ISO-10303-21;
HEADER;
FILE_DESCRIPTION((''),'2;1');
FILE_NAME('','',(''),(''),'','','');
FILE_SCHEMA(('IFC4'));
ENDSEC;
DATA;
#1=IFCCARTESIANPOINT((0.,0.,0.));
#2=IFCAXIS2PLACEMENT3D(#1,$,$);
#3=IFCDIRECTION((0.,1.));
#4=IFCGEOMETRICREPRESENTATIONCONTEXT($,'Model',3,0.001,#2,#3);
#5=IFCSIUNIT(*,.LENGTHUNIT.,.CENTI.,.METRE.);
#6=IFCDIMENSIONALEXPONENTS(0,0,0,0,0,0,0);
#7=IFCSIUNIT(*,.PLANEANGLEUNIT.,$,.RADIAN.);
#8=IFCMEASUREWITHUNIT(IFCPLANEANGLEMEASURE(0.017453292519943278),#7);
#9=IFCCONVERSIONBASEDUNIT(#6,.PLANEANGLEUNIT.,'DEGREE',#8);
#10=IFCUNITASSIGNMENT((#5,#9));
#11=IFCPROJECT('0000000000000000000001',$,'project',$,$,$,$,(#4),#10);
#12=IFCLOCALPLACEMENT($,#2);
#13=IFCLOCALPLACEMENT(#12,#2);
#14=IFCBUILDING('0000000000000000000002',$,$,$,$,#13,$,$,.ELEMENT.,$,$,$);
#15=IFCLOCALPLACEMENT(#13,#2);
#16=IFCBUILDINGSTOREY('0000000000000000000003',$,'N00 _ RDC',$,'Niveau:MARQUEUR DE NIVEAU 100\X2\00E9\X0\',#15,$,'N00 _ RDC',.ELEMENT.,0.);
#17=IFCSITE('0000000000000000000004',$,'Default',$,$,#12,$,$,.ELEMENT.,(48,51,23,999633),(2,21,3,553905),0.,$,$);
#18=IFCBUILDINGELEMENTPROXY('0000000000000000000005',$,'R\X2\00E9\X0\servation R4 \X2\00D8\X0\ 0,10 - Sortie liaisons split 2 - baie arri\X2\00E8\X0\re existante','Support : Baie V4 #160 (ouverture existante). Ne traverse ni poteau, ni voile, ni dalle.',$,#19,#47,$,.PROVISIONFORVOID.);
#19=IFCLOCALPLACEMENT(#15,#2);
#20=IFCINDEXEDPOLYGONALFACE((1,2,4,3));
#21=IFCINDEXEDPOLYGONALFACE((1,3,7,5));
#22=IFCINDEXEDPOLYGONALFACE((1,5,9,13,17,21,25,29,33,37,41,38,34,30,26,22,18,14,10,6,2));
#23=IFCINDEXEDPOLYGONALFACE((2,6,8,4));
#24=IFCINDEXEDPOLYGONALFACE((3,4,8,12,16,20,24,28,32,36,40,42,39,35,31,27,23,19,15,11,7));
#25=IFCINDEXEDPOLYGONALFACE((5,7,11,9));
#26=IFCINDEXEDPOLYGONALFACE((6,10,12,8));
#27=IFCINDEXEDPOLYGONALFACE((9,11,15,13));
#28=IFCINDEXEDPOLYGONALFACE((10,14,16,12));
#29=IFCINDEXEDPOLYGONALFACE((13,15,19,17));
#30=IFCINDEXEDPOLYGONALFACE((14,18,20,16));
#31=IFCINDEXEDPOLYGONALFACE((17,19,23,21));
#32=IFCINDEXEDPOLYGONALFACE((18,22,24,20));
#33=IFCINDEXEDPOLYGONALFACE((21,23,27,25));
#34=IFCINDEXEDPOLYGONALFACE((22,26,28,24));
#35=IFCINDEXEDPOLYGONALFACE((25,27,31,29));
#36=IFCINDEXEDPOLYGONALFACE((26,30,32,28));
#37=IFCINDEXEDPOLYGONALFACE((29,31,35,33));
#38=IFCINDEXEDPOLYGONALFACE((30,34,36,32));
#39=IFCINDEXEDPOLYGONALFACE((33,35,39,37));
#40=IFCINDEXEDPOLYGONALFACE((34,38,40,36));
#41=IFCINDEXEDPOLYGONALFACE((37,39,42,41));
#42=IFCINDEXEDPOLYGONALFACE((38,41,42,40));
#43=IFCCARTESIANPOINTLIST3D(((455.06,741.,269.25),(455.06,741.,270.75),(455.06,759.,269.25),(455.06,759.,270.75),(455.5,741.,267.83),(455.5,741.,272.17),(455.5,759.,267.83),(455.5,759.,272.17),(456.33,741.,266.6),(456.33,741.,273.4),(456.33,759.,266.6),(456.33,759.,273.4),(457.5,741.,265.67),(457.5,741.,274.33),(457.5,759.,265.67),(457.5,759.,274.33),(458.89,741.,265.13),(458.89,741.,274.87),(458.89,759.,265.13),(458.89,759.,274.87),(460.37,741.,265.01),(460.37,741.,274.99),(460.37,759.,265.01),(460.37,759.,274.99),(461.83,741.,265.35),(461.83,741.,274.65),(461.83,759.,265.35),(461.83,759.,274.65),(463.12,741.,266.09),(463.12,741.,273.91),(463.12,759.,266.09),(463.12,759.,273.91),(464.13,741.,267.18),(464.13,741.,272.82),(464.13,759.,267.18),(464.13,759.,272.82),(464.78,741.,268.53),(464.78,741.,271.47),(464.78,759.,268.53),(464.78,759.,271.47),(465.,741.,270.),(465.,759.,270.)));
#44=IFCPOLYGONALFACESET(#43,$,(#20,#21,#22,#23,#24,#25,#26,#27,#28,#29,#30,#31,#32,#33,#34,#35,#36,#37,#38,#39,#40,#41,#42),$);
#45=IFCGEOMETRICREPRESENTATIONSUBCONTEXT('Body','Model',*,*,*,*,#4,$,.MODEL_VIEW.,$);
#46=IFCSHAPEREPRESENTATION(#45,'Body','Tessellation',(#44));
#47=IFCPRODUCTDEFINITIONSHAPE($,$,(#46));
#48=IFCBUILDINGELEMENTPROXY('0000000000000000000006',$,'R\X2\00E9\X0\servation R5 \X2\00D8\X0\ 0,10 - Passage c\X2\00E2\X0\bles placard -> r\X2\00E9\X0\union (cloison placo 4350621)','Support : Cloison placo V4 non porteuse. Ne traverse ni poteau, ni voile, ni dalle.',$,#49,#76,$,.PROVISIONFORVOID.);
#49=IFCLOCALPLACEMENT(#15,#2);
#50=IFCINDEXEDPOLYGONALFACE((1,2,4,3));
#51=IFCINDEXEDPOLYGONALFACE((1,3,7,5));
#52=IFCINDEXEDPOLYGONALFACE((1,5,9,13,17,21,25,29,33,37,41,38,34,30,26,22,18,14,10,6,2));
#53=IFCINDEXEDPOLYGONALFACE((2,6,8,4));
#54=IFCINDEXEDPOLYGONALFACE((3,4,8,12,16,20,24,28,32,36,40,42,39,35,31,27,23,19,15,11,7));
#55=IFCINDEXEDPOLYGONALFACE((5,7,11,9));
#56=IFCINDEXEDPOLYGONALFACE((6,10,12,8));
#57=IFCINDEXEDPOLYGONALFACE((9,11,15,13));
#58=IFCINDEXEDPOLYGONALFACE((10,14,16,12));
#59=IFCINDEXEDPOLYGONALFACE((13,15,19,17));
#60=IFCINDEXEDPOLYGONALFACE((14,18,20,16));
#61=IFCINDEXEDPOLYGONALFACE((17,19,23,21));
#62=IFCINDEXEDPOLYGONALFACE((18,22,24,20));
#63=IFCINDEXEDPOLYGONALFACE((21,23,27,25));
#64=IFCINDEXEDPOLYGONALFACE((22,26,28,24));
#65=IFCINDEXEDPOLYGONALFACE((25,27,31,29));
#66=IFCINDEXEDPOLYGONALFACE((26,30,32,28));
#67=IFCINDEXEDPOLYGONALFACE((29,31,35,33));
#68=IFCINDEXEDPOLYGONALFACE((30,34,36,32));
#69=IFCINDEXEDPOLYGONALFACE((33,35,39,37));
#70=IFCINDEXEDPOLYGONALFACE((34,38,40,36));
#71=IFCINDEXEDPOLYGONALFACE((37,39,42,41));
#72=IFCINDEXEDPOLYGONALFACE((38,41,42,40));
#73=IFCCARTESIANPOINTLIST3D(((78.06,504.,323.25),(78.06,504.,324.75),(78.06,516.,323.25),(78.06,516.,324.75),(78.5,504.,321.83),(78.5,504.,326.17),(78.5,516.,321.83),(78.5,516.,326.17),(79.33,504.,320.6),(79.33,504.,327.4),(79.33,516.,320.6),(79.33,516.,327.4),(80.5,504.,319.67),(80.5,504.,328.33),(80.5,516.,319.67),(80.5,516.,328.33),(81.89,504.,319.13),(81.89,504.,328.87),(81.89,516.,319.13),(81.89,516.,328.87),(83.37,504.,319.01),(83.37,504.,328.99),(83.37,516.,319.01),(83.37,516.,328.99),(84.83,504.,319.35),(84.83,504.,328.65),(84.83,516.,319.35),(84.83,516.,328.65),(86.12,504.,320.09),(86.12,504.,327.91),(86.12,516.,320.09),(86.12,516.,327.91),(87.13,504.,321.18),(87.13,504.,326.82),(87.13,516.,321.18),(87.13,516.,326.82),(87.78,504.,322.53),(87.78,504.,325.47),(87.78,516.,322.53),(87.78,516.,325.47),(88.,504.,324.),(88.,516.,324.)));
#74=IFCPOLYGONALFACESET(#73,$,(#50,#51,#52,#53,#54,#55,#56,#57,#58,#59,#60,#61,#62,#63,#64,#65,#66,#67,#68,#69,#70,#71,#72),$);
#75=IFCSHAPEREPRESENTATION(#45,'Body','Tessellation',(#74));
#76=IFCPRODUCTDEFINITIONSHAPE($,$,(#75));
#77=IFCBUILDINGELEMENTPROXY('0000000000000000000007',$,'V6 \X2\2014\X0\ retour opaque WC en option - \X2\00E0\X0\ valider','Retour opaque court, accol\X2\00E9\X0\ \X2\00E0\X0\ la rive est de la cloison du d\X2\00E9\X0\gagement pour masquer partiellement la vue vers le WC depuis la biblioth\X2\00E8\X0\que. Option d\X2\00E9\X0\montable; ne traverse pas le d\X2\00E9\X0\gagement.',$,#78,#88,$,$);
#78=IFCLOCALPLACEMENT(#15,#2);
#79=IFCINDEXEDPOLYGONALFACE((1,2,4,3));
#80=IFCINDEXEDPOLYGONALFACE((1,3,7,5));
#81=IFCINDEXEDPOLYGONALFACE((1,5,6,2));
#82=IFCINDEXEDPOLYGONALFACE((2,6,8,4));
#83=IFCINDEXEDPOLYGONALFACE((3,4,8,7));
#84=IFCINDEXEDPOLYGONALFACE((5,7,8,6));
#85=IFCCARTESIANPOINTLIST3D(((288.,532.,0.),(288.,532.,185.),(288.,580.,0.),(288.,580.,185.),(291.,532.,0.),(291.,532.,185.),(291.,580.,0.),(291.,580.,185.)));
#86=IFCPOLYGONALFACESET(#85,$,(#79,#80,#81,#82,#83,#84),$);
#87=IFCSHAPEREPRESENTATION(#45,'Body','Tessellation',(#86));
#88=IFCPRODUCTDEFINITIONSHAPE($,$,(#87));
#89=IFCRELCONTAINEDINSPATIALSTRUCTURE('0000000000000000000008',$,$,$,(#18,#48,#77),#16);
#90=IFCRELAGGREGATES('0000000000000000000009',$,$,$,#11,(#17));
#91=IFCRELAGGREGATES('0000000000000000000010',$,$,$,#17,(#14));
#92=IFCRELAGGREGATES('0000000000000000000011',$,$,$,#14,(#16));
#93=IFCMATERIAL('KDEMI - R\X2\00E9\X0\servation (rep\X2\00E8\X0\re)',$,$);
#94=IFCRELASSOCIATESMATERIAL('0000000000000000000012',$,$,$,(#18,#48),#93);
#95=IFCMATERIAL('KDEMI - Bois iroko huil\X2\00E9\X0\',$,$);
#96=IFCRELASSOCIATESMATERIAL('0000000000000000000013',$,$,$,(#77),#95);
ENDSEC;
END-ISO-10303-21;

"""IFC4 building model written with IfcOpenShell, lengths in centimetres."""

from ifc_helpers import new_model, entity, si_unit, converted_unit, direction, frame, frame_2d, origin, origin_with_axes, origin_2d, place, context, subcontext, project, spatial, rectangle, circle, extrude, material, element, save


model = new_model("IFC4")

# Units and contexts
model_context = context("Model", 3, precision=0.001, world=origin(), true_north=direction((0.0, 1.0)))
body_context = subcontext(model_context, "Body", "Model", "MODEL_VIEW")
ifc_project = project(units=[si_unit("LENGTHUNIT", "METRE", prefix="CENTI"), converted_unit("PLANEANGLEUNIT", "DEGREE", entity("IfcPlaneAngleMeasure", 0.017453292519943278), si_unit("PLANEANGLEUNIT", "RADIAN"), dimensions=[0, 0, 0, 0, 0, 0, 0])], contexts=[model_context])

# Site, building, storey
site_placement = place(None, origin())
site = spatial("IfcSite", under=ifc_project, at=site_placement, Name="Default", CompositionType="ELEMENT", RefLatitude=(48, 51, 23, 999633), RefLongitude=(2, 21, 3, 553905), RefElevation=0.0)
building_placement = place(site_placement, origin())
building = spatial("IfcBuilding", under=site, at=building_placement, CompositionType="ELEMENT")
storey_placement = place(building_placement, origin())
storey = spatial("IfcBuildingStorey", under=building, at=storey_placement, Name="N00 _ RDC", ObjectType="Niveau:MARQUEUR DE NIVEAU 100é", LongName="N00 _ RDC", CompositionType="ELEMENT", Elevation=0.0)

# Shared definitions
ifc_material_1 = material(Name="KDEMI - Bois iroko huilé")

# Building element proxies
ifc_material_2 = material(Name="KDEMI - Réservation (repère)")
proxy_1_placement = place(storey_placement, origin_with_axes())
element("IfcBuildingElementProxy", 1, at=proxy_1_placement, inside=storey, material=ifc_material_2, Name="Réservation R4 Ø 0,10 - Sortie liaisons split 2 - baie arrière existante", Description="Support : Baie V4 #160 (ouverture existante). Ne traverse ni poteau, ni voile, ni dalle.", PredefinedType="PROVISIONFORVOID", context=body_context, shape_type="SweptSolid", body=[
    extrude(circle(Radius=5.0, at=origin_2d()), frame((460.0, 741.0, 270.0), z_axis=(0.0, 1.0, 0.0), x_axis=(1.0, 0.0, 0.0)), (0.0, 0.0, 1.0), 18.0),
])
proxy_2_placement = place(storey_placement, origin_with_axes())
element("IfcBuildingElementProxy", 2, at=proxy_2_placement, inside=storey, material=ifc_material_2, Name="Réservation R5 Ø 0,10 - Passage câbles placard -> réunion (cloison placo 4350621)", Description="Support : Cloison placo V4 non porteuse. Ne traverse ni poteau, ni voile, ni dalle.", PredefinedType="PROVISIONFORVOID", context=body_context, shape_type="SweptSolid", body=[
    extrude(circle(Radius=5.0, at=origin_2d()), frame((83.0, 504.0, 324.0), z_axis=(0.0, 1.0, 0.0), x_axis=(1.0, 0.0, 0.0)), (0.0, 0.0, 1.0), 12.0),
])
proxy_3_placement = place(storey_placement, origin_with_axes())
element("IfcBuildingElementProxy", 3, at=proxy_3_placement, inside=storey, material=ifc_material_1, Name="V6 — retour opaque WC en option - à valider", Description="Retour opaque court, accolé à la rive est de la cloison du dégagement pour masquer partiellement la vue vers le WC depuis la bibliothèque. Option démontable; ne traverse pas le dégagement.", context=body_context, shape_type="SweptSolid", body=[
    extrude(rectangle(XDim=3.0, YDim=48.0, at=frame_2d((289.5, 556.0))), origin(), (0.0, 0.0, 1.0), 185.0),
])

save(model, "model.ifc")
